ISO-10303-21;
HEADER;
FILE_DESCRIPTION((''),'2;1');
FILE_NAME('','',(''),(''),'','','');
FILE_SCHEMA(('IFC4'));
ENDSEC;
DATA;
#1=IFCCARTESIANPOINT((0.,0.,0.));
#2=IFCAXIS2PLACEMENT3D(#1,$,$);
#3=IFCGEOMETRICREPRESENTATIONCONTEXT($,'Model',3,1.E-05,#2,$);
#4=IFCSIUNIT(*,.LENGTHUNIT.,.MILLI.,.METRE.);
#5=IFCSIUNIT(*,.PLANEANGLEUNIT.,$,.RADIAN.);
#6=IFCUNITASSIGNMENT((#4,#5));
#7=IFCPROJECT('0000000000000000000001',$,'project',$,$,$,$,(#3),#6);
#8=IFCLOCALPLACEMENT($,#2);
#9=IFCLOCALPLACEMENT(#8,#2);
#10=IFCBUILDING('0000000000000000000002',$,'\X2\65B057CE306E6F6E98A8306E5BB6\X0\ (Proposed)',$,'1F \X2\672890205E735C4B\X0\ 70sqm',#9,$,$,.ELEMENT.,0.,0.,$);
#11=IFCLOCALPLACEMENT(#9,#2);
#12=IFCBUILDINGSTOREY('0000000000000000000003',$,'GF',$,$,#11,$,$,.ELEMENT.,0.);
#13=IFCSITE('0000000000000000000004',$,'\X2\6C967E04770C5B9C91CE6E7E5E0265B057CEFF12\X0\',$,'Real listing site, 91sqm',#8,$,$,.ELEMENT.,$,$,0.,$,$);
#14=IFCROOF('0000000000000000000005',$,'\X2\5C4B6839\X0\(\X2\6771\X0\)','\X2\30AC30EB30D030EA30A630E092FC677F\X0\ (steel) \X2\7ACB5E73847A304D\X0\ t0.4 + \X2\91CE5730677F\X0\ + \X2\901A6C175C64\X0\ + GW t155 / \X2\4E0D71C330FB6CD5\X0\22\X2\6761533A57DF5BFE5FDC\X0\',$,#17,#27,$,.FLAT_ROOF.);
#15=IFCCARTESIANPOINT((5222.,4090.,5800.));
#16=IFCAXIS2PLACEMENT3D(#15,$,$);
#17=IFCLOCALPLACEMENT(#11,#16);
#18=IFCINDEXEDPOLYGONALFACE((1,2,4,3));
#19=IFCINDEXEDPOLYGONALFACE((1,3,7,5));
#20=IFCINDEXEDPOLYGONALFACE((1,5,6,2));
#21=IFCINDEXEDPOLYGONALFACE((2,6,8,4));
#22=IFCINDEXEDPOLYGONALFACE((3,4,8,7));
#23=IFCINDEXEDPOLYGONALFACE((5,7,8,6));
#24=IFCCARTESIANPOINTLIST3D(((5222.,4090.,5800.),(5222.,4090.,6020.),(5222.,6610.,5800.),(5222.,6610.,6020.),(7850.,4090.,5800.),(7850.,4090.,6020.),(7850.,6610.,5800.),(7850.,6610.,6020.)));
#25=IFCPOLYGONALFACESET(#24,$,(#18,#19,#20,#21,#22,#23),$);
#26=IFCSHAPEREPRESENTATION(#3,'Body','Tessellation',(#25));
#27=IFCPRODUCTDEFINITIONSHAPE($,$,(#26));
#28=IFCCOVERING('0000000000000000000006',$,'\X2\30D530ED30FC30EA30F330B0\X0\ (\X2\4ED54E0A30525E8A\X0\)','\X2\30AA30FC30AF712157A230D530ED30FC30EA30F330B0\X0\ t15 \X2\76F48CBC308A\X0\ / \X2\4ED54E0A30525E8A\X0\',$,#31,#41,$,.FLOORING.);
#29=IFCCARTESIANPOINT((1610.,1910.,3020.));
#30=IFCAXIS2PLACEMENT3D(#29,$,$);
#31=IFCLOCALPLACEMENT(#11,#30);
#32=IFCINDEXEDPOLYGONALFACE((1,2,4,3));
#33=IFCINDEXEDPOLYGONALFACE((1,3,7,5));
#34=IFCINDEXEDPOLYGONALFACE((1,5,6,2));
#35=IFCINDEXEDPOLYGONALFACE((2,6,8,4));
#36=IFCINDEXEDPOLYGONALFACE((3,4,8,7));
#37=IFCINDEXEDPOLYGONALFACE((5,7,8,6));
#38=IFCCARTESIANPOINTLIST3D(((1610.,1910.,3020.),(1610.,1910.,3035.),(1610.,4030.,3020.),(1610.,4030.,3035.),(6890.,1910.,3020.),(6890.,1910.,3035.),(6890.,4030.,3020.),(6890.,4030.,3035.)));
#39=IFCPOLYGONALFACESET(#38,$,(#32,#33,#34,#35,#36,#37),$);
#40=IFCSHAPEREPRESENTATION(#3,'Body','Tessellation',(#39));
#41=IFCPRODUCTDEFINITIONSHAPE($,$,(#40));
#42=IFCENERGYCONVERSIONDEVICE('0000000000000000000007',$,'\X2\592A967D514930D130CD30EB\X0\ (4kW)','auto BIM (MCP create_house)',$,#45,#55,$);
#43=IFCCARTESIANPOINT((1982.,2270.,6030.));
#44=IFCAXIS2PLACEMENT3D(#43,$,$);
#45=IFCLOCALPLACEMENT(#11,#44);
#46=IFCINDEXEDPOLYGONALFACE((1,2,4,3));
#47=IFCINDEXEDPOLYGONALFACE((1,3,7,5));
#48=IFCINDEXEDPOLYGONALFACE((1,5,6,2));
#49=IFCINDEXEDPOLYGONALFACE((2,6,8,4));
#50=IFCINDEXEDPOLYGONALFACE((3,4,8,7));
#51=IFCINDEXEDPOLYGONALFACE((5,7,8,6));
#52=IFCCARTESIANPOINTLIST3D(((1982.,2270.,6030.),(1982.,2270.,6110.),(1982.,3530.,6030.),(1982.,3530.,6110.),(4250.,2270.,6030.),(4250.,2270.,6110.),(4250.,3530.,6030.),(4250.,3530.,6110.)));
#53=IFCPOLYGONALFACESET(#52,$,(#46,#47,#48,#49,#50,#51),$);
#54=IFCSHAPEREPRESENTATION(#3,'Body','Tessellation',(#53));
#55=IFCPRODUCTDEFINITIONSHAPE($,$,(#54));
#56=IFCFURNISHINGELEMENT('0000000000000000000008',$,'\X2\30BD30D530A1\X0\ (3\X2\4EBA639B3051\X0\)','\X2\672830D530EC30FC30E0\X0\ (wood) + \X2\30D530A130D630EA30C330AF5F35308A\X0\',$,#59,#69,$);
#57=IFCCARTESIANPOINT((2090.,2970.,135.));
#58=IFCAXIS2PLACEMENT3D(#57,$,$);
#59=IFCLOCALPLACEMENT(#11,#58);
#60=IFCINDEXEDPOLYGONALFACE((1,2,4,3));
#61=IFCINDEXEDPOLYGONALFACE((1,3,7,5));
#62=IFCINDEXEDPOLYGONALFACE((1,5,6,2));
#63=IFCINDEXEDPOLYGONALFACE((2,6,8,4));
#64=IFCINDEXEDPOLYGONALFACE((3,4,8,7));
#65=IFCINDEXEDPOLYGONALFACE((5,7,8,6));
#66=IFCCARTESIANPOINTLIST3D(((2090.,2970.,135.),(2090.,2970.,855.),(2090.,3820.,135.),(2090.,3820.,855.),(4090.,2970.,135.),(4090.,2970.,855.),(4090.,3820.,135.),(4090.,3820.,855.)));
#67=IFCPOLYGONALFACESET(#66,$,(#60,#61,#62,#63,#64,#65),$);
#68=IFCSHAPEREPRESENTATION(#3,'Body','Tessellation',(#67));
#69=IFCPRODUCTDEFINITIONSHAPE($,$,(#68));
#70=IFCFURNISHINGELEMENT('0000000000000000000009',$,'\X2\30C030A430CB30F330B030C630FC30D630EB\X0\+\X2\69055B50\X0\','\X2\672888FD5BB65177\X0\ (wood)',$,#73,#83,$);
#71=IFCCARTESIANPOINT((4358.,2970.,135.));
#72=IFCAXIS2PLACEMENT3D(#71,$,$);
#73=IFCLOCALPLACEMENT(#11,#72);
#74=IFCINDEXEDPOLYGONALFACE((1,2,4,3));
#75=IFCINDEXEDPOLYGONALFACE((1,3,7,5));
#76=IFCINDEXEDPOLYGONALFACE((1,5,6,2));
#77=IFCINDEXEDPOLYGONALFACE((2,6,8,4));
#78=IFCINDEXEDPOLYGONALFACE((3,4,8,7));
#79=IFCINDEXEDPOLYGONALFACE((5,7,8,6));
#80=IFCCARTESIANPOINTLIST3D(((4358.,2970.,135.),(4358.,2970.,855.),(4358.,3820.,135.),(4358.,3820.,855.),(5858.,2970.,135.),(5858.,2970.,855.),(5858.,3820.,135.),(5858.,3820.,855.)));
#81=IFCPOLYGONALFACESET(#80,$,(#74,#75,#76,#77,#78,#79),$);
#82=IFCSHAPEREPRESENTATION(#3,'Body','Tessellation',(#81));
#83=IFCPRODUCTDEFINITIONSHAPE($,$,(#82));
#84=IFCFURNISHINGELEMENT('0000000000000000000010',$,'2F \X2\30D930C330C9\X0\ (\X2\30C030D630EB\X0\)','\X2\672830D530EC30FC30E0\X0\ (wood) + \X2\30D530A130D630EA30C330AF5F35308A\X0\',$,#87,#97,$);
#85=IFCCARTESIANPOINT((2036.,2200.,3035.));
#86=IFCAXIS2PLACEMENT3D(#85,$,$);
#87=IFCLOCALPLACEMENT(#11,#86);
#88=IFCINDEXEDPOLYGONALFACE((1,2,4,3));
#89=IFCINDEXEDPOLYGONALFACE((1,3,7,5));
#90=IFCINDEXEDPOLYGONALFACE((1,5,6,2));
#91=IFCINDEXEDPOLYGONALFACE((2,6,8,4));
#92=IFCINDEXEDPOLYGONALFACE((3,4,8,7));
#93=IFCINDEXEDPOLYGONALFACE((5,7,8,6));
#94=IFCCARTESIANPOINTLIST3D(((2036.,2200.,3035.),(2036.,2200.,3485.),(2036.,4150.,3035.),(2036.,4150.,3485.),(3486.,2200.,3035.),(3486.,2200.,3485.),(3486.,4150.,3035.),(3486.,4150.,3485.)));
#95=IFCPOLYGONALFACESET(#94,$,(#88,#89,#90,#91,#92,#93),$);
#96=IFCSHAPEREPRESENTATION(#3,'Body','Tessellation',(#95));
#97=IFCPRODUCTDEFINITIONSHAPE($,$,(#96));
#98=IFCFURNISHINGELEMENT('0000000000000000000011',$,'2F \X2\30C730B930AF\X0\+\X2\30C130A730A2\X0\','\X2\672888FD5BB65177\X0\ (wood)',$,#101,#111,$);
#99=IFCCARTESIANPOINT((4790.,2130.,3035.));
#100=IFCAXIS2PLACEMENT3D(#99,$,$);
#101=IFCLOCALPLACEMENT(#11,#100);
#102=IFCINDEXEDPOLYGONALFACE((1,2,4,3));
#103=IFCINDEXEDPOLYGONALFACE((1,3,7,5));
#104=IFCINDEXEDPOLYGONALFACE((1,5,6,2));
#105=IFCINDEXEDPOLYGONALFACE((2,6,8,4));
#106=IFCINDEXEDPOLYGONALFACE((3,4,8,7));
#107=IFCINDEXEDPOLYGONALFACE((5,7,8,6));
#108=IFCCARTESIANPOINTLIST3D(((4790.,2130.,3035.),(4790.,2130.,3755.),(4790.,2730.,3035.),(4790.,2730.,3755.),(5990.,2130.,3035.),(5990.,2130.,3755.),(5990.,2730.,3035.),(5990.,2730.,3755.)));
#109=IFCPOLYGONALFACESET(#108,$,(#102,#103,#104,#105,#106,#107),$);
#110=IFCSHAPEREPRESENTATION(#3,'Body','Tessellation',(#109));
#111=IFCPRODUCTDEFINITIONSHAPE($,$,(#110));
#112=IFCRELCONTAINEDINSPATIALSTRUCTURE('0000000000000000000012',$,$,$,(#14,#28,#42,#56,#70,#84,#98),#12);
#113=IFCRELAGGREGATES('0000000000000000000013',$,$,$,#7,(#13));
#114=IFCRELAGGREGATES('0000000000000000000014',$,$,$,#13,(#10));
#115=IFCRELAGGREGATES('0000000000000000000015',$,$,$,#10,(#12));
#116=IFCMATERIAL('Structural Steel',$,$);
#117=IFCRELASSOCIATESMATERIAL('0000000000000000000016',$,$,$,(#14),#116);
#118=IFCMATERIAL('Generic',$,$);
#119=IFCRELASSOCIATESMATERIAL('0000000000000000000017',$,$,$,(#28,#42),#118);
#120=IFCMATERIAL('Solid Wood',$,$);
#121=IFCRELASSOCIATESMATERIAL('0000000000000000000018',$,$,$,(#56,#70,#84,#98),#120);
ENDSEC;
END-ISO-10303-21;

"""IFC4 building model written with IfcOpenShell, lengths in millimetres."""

from ifc_helpers import new_model, si_unit, frame, frame_2d, origin, place, context, project, spatial, rectangle, extrude, material, element, save


model = new_model("IFC4")

# Units and contexts
model_context = context("Model", 3, precision=1e-05, world=origin())
ifc_project = project(units=[si_unit("LENGTHUNIT", "METRE", prefix="MILLI"), si_unit("PLANEANGLEUNIT", "RADIAN")], contexts=[model_context])

# Site, building, storey
site_placement = place(None, origin())
site = spatial("IfcSite", under=ifc_project, at=site_placement, Name="沖縄県宜野湾市新城２", ObjectType="Real listing site, 91sqm", CompositionType="ELEMENT", RefElevation=0.0)
building_placement = place(site_placement, origin())
building = spatial("IfcBuilding", under=site, at=building_placement, Name="新城の潮風の家 (Proposed)", ObjectType="1F 木造平屋 70sqm", CompositionType="ELEMENT", ElevationOfRefHeight=0.0, ElevationOfTerrain=0.0)
storey_placement = place(building_placement, origin())
storey = spatial("IfcBuildingStorey", under=building, at=storey_placement, Name="GF", CompositionType="ELEMENT", Elevation=0.0)

# Shared definitions
ifc_material_1 = material(Name="Solid Wood")

# Roof
ifc_material_2 = material(Name="Structural Steel")
roof_1_placement = place(storey_placement, frame((5222.0, 4090.0, 5800.0)))
element("IfcRoof", 1, at=roof_1_placement, inside=storey, material=ifc_material_2, Name="屋根(東)", Description="ガルバリウム鋼板 (steel) 立平葺き t0.4 + 野地板 + 通気層 + GW t155 / 不燃・法22条区域対応", PredefinedType="FLAT_ROOF", context=model_context, shape_type="SweptSolid", body=[
    extrude(rectangle(XDim=2628.0, YDim=2520.0, at=frame_2d((1314.0, 1260.0))), frame((5222.0, 4090.0, 5800.0)), (0.0, 0.0, 1.0), 220.0),
])

# Covering
ifc_material_3 = material(Name="Generic")
covering_placement = place(storey_placement, frame((1610.0, 1910.0, 3020.0)))
element("IfcCovering", 2, at=covering_placement, inside=storey, material=ifc_material_3, Name="フローリング (仕上げ床)", Description="オーク無垢フローリング t15 直貼り / 仕上げ床", PredefinedType="FLOORING", context=model_context, shape_type="SweptSolid", body=[
    extrude(rectangle(XDim=5280.0, YDim=2120.0, at=frame_2d((2640.0, 1060.0))), frame((1610.0, 1910.0, 3020.0)), (0.0, 0.0, 1.0), 15.0),
])

# Energy conversion device
energy_conversion_device_placement = place(storey_placement, frame((1982.0, 2270.0, 6030.0)))
element("IfcEnergyConversionDevice", 3, at=energy_conversion_device_placement, inside=storey, material=ifc_material_3, Name="太陽光パネル (4kW)", Description="auto BIM (MCP create_house)", context=model_context, shape_type="SweptSolid", body=[
    extrude(rectangle(XDim=2268.0, YDim=1260.0, at=frame_2d((1134.0, 630.0))), frame((1982.0, 2270.0, 6030.0)), (0.0, 0.0, 1.0), 80.0),
])

# Furnishing elements
furnishing_1_placement = place(storey_placement, frame((2090.0, 2970.0, 135.0)))
element("IfcFurnishingElement", 4, at=furnishing_1_placement, inside=storey, material=ifc_material_1, Name="ソファ (3人掛け)", Description="木フレーム (wood) + ファブリック張り", context=model_context, shape_type="SweptSolid", body=[
    extrude(rectangle(XDim=2000.0, YDim=850.0, at=frame_2d((1000.0, 425.0))), frame((2090.0, 2970.0, 135.0)), (0.0, 0.0, 1.0), 720.0),
])
furnishing_2_placement = place(storey_placement, frame((4358.0, 2970.0, 135.0)))
element("IfcFurnishingElement", 5, at=furnishing_2_placement, inside=storey, material=ifc_material_1, Name="ダイニングテーブル+椅子", Description="木製家具 (wood)", context=model_context, shape_type="SweptSolid", body=[
    extrude(rectangle(XDim=1500.0, YDim=850.0, at=frame_2d((750.0, 425.0))), frame((4358.0, 2970.0, 135.0)), (0.0, 0.0, 1.0), 720.0),
])
furnishing_3_placement = place(storey_placement, frame((2036.0, 2200.0, 3035.0)))
element("IfcFurnishingElement", 6, at=furnishing_3_placement, inside=storey, material=ifc_material_1, Name="2F ベッド (ダブル)", Description="木フレーム (wood) + ファブリック張り", context=model_context, shape_type="SweptSolid", body=[
    extrude(rectangle(XDim=1450.0, YDim=1950.0, at=frame_2d((725.0, 975.0))), frame((2036.0, 2200.0, 3035.0)), (0.0, 0.0, 1.0), 450.0),
])
furnishing_4_placement = place(storey_placement, frame((4790.0, 2130.0, 3035.0)))
element("IfcFurnishingElement", 7, at=furnishing_4_placement, inside=storey, material=ifc_material_1, Name="2F デスク+チェア", Description="木製家具 (wood)", context=model_context, shape_type="SweptSolid", body=[
    extrude(rectangle(XDim=1200.0, YDim=600.0, at=frame_2d((600.0, 300.0))), frame((4790.0, 2130.0, 3035.0)), (0.0, 0.0, 1.0), 720.0),
])

save(model, "model.ifc")
